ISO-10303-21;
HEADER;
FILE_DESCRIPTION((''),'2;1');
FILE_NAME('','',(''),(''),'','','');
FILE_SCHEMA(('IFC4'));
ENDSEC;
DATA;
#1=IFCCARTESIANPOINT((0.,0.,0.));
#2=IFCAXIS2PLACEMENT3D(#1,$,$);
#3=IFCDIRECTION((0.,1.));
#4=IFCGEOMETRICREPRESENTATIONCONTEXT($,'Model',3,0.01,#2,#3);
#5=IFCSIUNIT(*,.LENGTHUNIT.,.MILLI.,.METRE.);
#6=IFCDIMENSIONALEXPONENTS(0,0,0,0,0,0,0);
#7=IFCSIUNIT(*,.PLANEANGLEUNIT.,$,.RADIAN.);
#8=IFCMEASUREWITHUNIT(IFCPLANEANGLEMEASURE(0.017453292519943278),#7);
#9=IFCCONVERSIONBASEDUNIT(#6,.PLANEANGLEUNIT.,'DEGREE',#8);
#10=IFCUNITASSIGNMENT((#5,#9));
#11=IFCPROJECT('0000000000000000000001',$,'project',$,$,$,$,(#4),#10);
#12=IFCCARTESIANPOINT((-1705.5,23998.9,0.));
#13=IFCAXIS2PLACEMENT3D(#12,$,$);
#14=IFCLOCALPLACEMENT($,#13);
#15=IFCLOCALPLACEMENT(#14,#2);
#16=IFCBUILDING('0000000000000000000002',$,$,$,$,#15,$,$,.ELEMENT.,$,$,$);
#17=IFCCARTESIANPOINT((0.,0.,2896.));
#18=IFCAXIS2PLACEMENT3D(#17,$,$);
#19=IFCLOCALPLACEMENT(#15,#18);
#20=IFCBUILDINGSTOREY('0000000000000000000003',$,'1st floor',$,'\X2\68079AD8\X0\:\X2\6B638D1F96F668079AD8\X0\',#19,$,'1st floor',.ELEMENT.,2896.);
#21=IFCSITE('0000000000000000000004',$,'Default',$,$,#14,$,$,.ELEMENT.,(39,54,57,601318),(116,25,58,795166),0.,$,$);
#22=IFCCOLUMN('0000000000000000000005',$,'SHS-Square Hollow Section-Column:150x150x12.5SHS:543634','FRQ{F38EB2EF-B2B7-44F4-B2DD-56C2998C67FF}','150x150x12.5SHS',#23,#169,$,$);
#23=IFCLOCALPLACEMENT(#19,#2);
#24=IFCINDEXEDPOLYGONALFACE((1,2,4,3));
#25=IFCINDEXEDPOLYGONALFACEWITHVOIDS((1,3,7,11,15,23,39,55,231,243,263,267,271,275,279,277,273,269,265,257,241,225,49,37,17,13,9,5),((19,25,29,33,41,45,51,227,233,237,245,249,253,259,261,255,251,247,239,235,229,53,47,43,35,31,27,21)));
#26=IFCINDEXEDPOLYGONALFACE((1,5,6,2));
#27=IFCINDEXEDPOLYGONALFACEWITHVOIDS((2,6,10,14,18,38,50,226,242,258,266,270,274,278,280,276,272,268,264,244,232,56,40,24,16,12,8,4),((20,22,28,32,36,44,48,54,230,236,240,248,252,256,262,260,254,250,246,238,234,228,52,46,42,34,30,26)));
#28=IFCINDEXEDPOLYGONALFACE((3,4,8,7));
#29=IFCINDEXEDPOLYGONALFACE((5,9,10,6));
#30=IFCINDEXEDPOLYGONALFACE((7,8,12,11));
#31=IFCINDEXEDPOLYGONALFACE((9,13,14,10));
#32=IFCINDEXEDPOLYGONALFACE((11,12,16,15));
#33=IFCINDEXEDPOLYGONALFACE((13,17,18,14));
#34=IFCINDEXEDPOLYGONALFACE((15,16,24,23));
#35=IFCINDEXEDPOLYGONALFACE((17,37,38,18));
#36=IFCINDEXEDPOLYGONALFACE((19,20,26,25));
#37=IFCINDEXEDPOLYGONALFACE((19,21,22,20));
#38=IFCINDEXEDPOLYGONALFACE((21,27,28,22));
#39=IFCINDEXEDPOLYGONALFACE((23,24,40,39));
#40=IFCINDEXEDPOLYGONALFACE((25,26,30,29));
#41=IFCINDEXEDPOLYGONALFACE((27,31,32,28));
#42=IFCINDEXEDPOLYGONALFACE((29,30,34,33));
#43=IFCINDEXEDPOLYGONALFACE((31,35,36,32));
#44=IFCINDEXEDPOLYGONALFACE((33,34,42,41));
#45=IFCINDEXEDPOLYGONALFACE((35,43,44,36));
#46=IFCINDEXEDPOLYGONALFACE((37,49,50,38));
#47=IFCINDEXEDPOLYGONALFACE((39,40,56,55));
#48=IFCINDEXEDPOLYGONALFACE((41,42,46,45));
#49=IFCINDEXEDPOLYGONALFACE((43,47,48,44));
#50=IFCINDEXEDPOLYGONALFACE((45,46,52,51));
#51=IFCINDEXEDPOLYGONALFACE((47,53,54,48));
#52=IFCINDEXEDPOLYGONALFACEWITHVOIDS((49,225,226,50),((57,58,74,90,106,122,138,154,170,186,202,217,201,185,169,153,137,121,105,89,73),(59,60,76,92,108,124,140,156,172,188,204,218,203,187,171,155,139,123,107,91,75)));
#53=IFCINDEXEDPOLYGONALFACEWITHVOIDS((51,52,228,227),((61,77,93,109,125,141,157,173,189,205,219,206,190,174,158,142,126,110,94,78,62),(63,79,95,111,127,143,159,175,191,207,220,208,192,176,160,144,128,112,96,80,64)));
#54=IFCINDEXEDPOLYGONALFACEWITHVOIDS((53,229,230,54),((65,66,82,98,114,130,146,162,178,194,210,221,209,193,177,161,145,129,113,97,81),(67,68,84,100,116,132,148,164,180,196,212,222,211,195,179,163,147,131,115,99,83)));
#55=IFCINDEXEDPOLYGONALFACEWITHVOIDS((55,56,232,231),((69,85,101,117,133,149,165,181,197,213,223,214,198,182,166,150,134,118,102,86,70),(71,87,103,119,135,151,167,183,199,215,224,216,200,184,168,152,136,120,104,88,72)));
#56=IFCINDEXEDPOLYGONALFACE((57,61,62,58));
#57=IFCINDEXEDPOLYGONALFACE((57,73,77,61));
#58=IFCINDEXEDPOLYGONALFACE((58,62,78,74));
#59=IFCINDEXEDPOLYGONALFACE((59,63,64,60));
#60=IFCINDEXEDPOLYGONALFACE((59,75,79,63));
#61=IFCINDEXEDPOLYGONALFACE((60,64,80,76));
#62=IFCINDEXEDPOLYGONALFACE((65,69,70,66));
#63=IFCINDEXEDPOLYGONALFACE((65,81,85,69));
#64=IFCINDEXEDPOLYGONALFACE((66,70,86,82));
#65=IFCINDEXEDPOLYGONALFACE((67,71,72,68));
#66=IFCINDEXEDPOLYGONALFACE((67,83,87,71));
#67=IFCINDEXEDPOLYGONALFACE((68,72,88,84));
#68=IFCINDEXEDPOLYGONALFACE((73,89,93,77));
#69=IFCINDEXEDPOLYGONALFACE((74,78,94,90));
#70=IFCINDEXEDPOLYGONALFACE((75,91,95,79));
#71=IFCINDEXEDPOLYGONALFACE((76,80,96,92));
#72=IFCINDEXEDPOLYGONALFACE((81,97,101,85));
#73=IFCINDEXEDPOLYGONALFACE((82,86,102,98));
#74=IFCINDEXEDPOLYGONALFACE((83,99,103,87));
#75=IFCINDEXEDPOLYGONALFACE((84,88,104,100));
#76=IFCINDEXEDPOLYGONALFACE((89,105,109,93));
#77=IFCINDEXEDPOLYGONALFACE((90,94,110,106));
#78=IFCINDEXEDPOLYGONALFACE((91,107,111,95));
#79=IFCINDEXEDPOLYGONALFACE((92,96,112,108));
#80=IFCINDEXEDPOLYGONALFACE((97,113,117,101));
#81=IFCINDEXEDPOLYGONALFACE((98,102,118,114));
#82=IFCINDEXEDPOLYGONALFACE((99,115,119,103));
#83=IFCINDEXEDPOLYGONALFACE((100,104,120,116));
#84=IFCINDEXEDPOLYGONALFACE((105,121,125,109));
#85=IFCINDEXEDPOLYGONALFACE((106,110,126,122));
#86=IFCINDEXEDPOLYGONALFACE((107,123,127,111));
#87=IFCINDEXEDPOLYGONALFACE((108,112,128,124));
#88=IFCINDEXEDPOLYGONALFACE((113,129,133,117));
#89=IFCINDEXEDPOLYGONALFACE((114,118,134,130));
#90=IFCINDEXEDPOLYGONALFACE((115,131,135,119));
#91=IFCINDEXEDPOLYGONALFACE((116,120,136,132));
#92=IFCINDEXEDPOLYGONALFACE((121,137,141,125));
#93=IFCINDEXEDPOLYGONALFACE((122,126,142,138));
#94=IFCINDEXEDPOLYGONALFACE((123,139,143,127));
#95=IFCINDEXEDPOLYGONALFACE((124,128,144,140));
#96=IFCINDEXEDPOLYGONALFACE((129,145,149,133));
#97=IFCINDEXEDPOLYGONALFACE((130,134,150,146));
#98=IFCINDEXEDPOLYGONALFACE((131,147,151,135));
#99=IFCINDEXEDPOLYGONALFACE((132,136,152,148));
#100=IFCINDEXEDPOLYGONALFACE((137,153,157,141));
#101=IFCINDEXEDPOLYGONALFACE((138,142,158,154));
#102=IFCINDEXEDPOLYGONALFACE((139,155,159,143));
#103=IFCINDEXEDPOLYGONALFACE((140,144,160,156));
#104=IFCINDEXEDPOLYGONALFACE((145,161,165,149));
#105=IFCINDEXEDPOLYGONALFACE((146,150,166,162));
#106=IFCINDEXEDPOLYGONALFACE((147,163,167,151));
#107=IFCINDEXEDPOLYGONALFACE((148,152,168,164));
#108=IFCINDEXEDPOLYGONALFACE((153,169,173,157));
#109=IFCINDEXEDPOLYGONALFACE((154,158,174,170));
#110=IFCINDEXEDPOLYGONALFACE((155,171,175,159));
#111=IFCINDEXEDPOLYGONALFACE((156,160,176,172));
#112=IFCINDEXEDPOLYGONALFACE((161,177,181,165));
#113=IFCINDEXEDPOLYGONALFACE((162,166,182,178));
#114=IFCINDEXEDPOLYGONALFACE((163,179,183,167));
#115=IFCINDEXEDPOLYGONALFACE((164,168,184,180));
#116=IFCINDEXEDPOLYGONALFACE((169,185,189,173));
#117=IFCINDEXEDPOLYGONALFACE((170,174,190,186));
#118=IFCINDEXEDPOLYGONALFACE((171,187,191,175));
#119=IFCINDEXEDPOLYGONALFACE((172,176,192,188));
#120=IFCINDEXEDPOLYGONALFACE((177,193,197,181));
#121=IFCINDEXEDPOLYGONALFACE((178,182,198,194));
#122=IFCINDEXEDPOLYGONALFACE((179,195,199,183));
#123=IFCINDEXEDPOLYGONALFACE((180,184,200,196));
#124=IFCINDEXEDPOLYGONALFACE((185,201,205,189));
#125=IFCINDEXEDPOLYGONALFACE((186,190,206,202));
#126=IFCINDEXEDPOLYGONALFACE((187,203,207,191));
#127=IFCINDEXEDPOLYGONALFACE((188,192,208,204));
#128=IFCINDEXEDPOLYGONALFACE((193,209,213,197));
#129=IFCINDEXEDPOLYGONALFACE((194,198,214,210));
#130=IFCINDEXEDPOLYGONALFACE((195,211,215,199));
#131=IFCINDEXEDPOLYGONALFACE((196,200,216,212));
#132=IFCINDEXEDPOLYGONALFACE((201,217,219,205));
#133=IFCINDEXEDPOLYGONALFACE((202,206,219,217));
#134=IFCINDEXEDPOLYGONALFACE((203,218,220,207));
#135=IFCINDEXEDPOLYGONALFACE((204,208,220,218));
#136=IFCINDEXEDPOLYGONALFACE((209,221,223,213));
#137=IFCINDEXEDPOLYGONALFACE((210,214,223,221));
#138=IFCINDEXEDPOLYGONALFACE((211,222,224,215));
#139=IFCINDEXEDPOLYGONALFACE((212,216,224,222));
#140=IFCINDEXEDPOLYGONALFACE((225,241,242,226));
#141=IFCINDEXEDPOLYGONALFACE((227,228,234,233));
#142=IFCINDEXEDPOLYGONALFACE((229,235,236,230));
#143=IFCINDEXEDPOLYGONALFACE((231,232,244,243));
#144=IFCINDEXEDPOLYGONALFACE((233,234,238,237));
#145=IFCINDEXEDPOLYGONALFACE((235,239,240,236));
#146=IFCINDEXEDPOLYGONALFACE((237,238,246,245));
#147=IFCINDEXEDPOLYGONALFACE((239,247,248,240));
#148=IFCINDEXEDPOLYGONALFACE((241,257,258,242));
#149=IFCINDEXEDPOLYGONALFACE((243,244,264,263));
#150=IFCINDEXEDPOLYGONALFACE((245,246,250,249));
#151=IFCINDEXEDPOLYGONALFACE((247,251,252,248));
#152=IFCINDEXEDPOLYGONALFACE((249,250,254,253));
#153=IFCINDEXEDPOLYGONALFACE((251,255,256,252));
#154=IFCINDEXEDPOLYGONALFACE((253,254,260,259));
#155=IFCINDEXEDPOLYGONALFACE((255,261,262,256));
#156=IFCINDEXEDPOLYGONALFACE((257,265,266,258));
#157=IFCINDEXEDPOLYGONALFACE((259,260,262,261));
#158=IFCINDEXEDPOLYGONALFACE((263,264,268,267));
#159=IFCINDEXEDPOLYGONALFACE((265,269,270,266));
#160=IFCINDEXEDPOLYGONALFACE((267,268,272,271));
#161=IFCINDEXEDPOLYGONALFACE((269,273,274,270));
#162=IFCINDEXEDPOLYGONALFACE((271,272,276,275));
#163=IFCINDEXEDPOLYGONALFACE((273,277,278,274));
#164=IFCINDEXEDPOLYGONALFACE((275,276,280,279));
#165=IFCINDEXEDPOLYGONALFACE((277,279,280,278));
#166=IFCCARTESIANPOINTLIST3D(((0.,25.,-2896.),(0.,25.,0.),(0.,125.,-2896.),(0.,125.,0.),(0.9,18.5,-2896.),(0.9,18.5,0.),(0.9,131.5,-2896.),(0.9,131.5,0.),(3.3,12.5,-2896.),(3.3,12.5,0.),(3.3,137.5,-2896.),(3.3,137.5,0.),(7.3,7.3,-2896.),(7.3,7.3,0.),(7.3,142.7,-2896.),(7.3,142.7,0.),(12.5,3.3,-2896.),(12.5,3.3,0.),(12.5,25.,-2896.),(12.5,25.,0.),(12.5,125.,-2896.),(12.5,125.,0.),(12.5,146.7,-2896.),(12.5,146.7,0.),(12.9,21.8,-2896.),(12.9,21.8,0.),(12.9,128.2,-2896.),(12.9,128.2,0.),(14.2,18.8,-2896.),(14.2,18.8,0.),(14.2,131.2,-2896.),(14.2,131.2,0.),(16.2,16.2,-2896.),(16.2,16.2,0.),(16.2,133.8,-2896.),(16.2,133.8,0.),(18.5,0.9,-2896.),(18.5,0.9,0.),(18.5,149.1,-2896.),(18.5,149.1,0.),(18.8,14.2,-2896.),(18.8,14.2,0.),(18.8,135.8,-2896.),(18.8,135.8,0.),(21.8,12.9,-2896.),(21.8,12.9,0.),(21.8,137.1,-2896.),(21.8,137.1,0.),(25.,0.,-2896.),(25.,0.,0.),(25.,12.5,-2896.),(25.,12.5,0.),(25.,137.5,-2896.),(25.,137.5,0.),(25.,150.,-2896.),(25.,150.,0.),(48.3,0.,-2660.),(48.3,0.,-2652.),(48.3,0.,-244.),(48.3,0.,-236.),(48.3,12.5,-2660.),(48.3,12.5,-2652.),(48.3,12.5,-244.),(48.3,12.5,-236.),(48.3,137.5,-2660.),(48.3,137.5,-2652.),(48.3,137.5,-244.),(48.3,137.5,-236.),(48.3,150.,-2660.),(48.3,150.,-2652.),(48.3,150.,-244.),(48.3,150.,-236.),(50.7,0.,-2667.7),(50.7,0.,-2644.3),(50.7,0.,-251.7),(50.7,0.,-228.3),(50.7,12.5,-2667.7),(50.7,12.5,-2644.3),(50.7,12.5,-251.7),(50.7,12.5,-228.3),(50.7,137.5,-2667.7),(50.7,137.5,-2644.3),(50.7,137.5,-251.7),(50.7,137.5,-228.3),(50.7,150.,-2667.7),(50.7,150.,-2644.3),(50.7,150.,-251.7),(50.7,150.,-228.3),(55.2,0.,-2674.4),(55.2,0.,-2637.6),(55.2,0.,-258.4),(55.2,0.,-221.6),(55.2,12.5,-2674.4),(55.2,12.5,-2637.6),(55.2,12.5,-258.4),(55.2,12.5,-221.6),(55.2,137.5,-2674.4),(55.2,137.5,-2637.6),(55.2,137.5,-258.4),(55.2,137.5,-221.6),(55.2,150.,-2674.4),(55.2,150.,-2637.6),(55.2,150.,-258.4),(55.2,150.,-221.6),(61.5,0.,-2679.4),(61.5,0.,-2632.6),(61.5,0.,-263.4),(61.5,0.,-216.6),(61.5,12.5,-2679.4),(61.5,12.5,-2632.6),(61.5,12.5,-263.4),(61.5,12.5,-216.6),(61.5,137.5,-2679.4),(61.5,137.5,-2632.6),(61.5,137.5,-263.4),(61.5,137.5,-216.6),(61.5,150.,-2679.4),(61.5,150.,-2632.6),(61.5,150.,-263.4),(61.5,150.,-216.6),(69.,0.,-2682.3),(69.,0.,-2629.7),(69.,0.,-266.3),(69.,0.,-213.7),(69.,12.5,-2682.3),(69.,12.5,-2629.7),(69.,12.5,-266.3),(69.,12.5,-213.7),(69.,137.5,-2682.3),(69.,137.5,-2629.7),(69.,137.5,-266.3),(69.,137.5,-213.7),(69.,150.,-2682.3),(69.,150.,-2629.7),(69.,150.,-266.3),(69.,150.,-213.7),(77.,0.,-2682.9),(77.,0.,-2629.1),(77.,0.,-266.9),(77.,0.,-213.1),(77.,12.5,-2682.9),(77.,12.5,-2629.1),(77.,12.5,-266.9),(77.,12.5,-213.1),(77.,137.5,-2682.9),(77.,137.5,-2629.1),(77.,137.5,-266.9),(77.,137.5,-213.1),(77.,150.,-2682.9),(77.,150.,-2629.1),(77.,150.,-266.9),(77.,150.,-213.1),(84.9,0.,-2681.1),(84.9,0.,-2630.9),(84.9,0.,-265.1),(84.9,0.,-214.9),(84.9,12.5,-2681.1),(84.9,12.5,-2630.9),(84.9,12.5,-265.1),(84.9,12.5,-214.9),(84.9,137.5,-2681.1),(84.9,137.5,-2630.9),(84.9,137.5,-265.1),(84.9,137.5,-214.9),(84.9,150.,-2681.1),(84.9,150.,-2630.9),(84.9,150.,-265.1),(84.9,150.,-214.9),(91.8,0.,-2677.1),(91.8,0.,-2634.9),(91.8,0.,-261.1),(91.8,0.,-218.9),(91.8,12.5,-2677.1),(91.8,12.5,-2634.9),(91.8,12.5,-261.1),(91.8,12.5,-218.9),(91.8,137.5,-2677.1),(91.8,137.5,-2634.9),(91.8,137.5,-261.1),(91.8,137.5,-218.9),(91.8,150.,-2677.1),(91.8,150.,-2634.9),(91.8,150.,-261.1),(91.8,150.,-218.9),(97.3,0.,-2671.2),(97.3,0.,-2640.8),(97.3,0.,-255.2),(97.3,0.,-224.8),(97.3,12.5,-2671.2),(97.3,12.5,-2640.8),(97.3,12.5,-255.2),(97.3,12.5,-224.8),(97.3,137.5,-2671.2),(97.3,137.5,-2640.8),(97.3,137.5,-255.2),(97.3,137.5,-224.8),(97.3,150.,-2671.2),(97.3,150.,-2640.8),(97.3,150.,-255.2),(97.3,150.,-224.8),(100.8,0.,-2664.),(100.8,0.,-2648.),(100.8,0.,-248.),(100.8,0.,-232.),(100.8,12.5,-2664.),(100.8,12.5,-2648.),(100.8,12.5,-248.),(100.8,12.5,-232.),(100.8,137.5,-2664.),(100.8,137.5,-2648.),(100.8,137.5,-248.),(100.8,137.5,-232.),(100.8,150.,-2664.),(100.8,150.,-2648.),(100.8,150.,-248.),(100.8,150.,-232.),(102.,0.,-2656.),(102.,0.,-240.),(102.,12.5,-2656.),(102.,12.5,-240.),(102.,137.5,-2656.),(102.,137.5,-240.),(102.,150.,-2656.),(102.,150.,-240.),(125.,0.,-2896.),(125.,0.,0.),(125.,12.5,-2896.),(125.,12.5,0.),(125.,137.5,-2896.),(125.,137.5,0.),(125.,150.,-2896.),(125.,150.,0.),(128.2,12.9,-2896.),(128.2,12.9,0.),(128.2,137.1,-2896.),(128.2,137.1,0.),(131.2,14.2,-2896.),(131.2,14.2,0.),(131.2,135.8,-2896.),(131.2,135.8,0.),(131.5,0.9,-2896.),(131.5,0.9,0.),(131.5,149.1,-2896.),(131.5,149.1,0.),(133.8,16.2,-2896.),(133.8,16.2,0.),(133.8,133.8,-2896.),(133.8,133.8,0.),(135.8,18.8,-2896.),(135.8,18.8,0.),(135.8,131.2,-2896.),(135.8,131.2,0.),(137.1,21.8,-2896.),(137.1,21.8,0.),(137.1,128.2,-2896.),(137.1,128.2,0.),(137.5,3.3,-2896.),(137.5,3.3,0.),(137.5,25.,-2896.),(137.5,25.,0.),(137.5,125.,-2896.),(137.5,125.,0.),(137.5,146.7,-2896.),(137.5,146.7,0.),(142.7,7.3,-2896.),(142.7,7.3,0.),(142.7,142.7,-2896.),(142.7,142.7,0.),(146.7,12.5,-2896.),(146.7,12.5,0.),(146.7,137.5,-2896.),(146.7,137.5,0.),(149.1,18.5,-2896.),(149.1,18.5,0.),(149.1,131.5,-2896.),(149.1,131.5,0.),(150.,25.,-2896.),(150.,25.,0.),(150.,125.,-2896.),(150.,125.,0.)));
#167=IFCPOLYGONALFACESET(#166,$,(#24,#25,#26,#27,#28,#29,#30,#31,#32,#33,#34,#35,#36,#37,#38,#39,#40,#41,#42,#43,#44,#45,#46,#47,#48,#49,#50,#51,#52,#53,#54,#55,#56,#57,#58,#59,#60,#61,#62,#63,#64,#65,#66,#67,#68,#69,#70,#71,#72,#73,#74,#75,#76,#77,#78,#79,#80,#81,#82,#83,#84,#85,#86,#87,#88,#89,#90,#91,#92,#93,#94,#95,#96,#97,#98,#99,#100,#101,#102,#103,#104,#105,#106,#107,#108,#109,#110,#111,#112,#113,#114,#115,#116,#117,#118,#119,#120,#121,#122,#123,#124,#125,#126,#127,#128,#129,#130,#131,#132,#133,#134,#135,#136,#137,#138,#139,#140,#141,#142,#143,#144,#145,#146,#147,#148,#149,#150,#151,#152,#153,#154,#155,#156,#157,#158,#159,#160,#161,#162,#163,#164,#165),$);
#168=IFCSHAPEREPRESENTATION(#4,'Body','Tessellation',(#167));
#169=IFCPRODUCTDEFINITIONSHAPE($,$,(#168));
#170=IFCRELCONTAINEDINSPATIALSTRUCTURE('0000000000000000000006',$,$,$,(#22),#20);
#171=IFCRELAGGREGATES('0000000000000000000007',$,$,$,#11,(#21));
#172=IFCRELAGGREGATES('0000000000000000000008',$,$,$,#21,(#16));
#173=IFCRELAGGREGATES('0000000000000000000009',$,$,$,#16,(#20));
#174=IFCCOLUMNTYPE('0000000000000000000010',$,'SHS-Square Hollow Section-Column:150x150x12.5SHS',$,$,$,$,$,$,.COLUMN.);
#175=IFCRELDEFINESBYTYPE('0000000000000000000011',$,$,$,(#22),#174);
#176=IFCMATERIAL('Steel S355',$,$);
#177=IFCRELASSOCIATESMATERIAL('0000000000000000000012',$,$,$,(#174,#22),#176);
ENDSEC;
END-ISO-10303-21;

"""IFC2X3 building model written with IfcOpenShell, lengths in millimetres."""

from ifc_helpers import new_model, entity, si_unit, converted_unit, direction, frame, frame_2d, origin, origin_2d, place, context, project, spatial, circle_curve, hollow_rectangle, outline, extrude, material, type_object, element, save


model = new_model("IFC2X3")

# Units and contexts
model_context = context("Model", 3, precision=0.01, world=origin(), true_north=direction((0.0, 1.0)))
ifc_project = project(units=[si_unit("LENGTHUNIT", "METRE", prefix="MILLI"), converted_unit("PLANEANGLEUNIT", "DEGREE", entity("IfcPlaneAngleMeasure", 0.017453292519943278), si_unit("PLANEANGLEUNIT", "RADIAN"), dimensions=[0, 0, 0, 0, 0, 0, 0])], contexts=[model_context])

# Site, building, storey
site_placement = place(None, frame((-1705.5, 23998.9, 0.0)))
site = spatial("IfcSite", under=ifc_project, at=site_placement, Name="Default", CompositionType="ELEMENT", RefLatitude=(39, 54, 57, 601318), RefLongitude=(116, 25, 58, 795166), RefElevation=0.0)
building_placement = place(site_placement, origin())
building = spatial("IfcBuilding", under=site, at=building_placement, CompositionType="ELEMENT")
storey_placement = place(building_placement, frame((0.0, 0.0, 2896.0)))
storey = spatial("IfcBuildingStorey", under=building, at=storey_placement, Name="1st floor", ObjectType="标高:正负零标高", LongName="1st floor", CompositionType="ELEMENT", Elevation=2896.0)

# Column, openings
ifc_material_1 = material(Name="Steel S355")
column_type = type_object("IfcColumnType", Name="SHS-Square Hollow Section-Column:150x150x12.5SHS", PredefinedType="COLUMN", material=ifc_material_1)
column_1_placement = place(storey_placement, frame((75.0, 75.0, 0.0), z_axis=(0.0, 0.0, 1.0), x_axis=(0.0, -1.0, 0.0)))
column_1 = element("IfcColumn", 1, at=column_1_placement, inside=storey, type_object=column_type, material=ifc_material_1, Name="SHS-Square Hollow Section-Column:150x150x12.5SHS:543634", Description="FRQ{F38EB2EF-B2B7-44F4-B2DD-56C2998C67FF}", ObjectType="150x150x12.5SHS", context=model_context, shape_type="SweptSolid", body=[
    extrude(hollow_rectangle(XDim=150.0, YDim=150.0, WallThickness=12.5, InnerFilletRadius=12.5, OuterFilletRadius=25.0, at=origin_2d()), origin(), (0.0, 0.0, -1.0), 2896.0),
])
opening_1_placement = place(column_1_placement, frame((-175.1, 0.0, -2896.0), z_axis=(1.0, 0.0, 0.0), x_axis=(0.0, 1.0, 0.0)))
element("IfcOpeningElement", 2, at=opening_1_placement, cuts=column_1, ObjectType="Opening", context=model_context, shape_type="SweptSolid", body=[
    extrude(outline(circle_curve(frame_2d((0.0, 240.0), x_axis=(1.0, 0.0)), 27.0)), origin(), (0.0, 0.0, 1.0), 350.2),
])
opening_2_placement = place(column_1_placement, frame((-175.1, 0.0, 0.0), z_axis=(1.0, 0.0, 0.0), x_axis=(0.0, 1.0, 0.0)))
element("IfcOpeningElement", 3, at=opening_2_placement, cuts=column_1, ObjectType="Opening", context=model_context, shape_type="SweptSolid", body=[
    extrude(outline(circle_curve(frame_2d((0.0, -240.0), x_axis=(1.0, 0.0)), 27.0)), origin(), (0.0, 0.0, 1.0), 350.2),
])

save(model, "model.ifc")
